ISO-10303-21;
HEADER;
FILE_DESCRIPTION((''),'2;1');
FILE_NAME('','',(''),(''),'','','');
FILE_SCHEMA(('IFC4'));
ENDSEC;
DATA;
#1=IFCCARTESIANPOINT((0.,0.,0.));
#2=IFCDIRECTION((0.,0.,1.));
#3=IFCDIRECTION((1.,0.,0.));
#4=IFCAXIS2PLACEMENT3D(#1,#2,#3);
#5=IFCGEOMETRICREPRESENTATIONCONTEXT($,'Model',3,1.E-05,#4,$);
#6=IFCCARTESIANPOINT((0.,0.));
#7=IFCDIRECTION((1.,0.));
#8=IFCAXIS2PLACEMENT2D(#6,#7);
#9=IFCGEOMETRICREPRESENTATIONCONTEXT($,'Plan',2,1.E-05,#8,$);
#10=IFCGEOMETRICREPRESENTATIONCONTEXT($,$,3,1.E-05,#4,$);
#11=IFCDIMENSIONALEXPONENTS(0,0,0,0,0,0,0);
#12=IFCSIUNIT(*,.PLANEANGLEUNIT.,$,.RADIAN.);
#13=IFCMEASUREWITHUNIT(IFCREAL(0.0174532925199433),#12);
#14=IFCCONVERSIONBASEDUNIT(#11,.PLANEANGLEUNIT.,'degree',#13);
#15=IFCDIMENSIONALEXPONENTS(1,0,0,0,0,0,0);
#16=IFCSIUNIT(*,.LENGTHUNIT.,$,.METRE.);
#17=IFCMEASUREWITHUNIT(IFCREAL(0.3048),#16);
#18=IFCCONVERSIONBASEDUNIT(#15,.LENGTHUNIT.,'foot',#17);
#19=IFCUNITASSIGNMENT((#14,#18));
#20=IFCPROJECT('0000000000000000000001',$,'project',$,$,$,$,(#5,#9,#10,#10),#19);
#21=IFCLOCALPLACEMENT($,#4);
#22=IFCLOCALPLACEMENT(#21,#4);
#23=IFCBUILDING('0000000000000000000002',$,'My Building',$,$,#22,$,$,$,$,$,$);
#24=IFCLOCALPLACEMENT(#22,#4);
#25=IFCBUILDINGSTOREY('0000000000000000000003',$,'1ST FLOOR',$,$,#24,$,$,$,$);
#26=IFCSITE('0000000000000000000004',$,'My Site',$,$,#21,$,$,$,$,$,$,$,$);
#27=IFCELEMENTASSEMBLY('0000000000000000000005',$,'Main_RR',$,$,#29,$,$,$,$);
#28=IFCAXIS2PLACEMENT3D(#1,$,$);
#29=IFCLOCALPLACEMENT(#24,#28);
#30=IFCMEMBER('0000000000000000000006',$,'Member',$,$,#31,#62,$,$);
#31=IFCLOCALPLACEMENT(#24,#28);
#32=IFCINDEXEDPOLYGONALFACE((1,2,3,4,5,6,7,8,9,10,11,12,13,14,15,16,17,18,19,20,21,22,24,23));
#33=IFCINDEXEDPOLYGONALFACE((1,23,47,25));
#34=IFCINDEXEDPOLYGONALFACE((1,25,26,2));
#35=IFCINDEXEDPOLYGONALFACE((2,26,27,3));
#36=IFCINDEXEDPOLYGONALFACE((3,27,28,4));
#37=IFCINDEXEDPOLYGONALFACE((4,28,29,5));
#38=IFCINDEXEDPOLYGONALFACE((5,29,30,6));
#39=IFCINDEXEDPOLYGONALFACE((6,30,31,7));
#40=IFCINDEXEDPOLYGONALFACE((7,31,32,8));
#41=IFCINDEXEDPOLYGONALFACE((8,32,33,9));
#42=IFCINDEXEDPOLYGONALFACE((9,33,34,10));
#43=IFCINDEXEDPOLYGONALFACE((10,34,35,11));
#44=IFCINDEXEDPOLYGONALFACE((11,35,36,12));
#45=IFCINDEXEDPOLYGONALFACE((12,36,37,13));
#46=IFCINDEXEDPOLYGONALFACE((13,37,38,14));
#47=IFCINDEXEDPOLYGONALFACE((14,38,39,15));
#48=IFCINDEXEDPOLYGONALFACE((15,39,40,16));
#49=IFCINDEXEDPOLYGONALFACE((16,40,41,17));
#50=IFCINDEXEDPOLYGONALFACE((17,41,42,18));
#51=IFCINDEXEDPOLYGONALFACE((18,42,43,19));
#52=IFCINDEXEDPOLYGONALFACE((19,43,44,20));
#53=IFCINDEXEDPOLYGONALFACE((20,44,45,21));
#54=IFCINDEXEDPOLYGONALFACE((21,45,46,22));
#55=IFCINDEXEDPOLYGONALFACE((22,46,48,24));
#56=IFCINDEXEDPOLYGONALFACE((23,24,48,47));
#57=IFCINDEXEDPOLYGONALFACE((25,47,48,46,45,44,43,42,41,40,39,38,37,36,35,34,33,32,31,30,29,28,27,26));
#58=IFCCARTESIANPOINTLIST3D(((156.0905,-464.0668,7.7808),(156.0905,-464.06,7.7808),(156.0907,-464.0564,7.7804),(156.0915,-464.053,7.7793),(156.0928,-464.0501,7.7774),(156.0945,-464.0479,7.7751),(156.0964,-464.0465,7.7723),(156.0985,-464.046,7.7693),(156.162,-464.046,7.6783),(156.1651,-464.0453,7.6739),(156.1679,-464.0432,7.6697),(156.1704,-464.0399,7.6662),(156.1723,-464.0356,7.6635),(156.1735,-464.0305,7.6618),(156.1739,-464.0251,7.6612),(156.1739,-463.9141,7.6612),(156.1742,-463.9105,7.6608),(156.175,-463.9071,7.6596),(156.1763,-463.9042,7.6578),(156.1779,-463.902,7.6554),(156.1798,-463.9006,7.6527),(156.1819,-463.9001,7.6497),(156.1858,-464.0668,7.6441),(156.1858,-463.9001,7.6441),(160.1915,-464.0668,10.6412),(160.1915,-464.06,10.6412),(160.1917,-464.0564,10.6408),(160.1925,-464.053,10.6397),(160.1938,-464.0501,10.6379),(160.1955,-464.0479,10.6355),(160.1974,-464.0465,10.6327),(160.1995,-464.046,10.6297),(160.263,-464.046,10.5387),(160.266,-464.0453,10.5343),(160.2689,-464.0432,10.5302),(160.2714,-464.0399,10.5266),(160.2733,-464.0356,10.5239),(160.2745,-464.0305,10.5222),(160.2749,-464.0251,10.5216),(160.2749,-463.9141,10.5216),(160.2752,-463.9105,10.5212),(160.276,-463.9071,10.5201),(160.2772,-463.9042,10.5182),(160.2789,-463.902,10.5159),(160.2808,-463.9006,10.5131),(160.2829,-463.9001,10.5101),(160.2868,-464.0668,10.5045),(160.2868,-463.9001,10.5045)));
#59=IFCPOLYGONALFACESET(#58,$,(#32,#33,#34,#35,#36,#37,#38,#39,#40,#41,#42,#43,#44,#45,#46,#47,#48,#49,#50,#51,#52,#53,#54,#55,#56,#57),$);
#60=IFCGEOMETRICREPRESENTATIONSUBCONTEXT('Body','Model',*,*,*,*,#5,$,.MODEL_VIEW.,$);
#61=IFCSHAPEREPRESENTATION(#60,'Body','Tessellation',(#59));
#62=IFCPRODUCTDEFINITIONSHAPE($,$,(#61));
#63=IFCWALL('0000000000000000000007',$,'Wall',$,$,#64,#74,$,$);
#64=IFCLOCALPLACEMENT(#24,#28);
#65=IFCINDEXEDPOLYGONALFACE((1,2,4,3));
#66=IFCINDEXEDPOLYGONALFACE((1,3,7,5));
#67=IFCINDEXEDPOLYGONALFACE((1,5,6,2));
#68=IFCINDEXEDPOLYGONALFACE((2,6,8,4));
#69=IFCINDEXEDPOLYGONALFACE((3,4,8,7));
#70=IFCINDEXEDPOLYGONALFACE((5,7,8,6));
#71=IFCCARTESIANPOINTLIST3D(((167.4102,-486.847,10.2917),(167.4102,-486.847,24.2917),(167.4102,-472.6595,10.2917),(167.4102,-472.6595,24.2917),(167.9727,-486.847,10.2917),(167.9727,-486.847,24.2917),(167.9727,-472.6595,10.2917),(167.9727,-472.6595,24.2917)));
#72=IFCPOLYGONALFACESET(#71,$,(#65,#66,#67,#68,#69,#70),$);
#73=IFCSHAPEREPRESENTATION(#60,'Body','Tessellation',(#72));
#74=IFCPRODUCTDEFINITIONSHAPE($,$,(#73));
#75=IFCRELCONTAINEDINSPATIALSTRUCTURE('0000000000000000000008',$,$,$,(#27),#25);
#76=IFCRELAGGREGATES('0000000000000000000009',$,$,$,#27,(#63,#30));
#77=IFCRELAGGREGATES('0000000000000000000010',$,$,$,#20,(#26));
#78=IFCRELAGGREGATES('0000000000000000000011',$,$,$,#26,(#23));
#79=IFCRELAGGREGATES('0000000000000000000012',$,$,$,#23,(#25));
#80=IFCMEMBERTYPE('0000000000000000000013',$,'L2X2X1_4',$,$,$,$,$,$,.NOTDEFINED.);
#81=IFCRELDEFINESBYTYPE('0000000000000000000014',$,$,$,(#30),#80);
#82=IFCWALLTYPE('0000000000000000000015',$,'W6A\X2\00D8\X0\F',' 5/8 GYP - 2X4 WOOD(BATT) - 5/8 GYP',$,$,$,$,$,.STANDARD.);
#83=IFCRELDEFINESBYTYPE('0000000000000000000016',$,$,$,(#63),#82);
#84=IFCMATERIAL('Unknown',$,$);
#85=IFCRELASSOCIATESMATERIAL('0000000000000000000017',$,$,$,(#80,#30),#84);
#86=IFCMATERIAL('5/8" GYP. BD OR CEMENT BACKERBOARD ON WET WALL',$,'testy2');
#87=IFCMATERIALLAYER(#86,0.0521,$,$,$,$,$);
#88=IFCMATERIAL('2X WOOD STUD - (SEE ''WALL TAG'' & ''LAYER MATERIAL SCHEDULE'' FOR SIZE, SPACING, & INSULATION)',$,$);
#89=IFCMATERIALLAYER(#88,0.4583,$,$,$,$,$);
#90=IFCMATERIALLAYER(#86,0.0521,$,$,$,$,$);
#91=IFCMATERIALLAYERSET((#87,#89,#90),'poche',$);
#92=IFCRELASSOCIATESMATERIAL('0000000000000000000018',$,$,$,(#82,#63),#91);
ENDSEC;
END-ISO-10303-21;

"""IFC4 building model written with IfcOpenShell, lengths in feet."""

from ifc_helpers import new_model, entity, si_unit, converted_unit, frame, origin_with_axes, origin_2d_with_axis, place, context, subcontext, project, spatial, indexed_curve, l_section, outline, extrude, material, layer, layer_set, layer_usage, material_profile, profile_set, profile_usage, type_object, element, aggregate, save


model = new_model("IFC4")

# Units and contexts
model_context = context("Model", 3, precision=1e-05, world=origin_with_axes())
plan_context = context("Plan", 2, precision=1e-05, world=origin_2d_with_axis())
context_of_model = context(None, 3, precision=1e-05, world=origin_with_axes())
body_context_1 = subcontext(model_context, "Body", "Model", "MODEL_VIEW")
ifc_project = project(units=[converted_unit("PLANEANGLEUNIT", "degree", entity("IfcReal", 0.0174532925199433), si_unit("PLANEANGLEUNIT", "RADIAN"), dimensions=[0, 0, 0, 0, 0, 0, 0]), converted_unit("LENGTHUNIT", "foot", entity("IfcReal", 0.3048), si_unit("LENGTHUNIT", "METRE"), dimensions=[1, 0, 0, 0, 0, 0, 0])], contexts=[model_context, plan_context, context_of_model, context_of_model])

# Site, building, storey
site_placement = place(None, origin_with_axes())
site = spatial("IfcSite", under=ifc_project, at=site_placement, Name="My Site")
building_placement = place(site_placement, origin_with_axes())
building = spatial("IfcBuilding", under=site, at=building_placement, Name="My Building")
storey_placement = place(building_placement, origin_with_axes())
storey = spatial("IfcBuildingStorey", under=building, at=storey_placement, Name="1ST FLOOR")

# Element assembly, member
assembly_1_placement = place(storey_placement, origin_with_axes())
assembly_1 = element("IfcElementAssembly", 1, at=assembly_1_placement, inside=storey, Name="Main_RR")
ifc_material_1 = material(Name="Unknown")
ifc_material_profile_1 = material_profile(ifc_material_1, l_section(Depth=0.1667, Width=0.1667, Thickness=0.0208, FilletRadius=0.0208, EdgeRadius=0.014))
ifc_profile_set_1 = profile_set([ifc_material_profile_1])
member_type = type_object("IfcMemberType", Name="L2X2X1_4", PredefinedType="NOTDEFINED", material=ifc_profile_set_1)
ifc_profile_usage_1 = profile_usage(ifc_profile_set_1, cardinal=5)
member_1_placement = place(assembly_1_placement, frame((156.1381, -463.9835, 7.7124), z_axis=(0.820194, 0.0, 0.572085), x_axis=(0.0, 1.0, 0.0)))
member_1 = element("IfcMember", 2, at=member_1_placement, type_object=member_type, material=ifc_profile_usage_1, Name="Member", context=body_context_1, shape_type="SweptSolid", body=[
    extrude(l_section(Depth=0.1667, Width=0.1667, Thickness=0.0208, FilletRadius=0.0208, EdgeRadius=0.014), origin_with_axes(), (0.0, 0.0, 1.0), 5.0),
])

# Shared definitions
ifc_material_2 = material(Name="5/8\" GYP. BD OR CEMENT BACKERBOARD ON WET WALL", Category="testy2")
ifc_material_3 = material(Name="2X WOOD STUD - (SEE 'WALL TAG' & 'LAYER MATERIAL SCHEDULE' FOR SIZE, SPACING, & INSULATION)")

# Wall
ifc_layer_1 = layer(ifc_material_2, 0.0521)
ifc_layer_2 = layer(ifc_material_3, 0.4583)
ifc_layer_3 = layer(ifc_material_2, 0.0521)
ifc_layer_set_1 = layer_set([ifc_layer_1, ifc_layer_2, ifc_layer_3], Name="poche")
ifc_layer_usage_1 = layer_usage(ifc_layer_set_1, "AXIS2", "POSITIVE", 0.0)
wall_type_1 = type_object("IfcWallType", Name="W6AØF", Description=" 5/8 GYP - 2X4 WOOD(BATT) - 5/8 GYP", PredefinedType="STANDARD", material=ifc_layer_set_1)
wall_1_placement = place(assembly_1_placement, frame((167.4102, -472.6595, 10.2917), z_axis=(0.0, 0.0, 1.0), x_axis=(0.0, -1.0, 0.0)))
wall_1 = element("IfcWall", 3, at=wall_1_placement, type_object=wall_type_1, material=ifc_layer_usage_1, Name="Wall", context=body_context_1, shape_type="SweptSolid", body=[
    extrude(outline(indexed_curve([(0.0, 0.0), (0.0, 0.5625), (14.1875, 0.5625), (14.1875, 0.0), (0.0, 0.0)], self_intersect=False)), origin_with_axes(), (0.0, 0.0, 1.0), 14.0),
])

aggregate(assembly_1, [wall_1, member_1])

save(model, "model.ifc")
